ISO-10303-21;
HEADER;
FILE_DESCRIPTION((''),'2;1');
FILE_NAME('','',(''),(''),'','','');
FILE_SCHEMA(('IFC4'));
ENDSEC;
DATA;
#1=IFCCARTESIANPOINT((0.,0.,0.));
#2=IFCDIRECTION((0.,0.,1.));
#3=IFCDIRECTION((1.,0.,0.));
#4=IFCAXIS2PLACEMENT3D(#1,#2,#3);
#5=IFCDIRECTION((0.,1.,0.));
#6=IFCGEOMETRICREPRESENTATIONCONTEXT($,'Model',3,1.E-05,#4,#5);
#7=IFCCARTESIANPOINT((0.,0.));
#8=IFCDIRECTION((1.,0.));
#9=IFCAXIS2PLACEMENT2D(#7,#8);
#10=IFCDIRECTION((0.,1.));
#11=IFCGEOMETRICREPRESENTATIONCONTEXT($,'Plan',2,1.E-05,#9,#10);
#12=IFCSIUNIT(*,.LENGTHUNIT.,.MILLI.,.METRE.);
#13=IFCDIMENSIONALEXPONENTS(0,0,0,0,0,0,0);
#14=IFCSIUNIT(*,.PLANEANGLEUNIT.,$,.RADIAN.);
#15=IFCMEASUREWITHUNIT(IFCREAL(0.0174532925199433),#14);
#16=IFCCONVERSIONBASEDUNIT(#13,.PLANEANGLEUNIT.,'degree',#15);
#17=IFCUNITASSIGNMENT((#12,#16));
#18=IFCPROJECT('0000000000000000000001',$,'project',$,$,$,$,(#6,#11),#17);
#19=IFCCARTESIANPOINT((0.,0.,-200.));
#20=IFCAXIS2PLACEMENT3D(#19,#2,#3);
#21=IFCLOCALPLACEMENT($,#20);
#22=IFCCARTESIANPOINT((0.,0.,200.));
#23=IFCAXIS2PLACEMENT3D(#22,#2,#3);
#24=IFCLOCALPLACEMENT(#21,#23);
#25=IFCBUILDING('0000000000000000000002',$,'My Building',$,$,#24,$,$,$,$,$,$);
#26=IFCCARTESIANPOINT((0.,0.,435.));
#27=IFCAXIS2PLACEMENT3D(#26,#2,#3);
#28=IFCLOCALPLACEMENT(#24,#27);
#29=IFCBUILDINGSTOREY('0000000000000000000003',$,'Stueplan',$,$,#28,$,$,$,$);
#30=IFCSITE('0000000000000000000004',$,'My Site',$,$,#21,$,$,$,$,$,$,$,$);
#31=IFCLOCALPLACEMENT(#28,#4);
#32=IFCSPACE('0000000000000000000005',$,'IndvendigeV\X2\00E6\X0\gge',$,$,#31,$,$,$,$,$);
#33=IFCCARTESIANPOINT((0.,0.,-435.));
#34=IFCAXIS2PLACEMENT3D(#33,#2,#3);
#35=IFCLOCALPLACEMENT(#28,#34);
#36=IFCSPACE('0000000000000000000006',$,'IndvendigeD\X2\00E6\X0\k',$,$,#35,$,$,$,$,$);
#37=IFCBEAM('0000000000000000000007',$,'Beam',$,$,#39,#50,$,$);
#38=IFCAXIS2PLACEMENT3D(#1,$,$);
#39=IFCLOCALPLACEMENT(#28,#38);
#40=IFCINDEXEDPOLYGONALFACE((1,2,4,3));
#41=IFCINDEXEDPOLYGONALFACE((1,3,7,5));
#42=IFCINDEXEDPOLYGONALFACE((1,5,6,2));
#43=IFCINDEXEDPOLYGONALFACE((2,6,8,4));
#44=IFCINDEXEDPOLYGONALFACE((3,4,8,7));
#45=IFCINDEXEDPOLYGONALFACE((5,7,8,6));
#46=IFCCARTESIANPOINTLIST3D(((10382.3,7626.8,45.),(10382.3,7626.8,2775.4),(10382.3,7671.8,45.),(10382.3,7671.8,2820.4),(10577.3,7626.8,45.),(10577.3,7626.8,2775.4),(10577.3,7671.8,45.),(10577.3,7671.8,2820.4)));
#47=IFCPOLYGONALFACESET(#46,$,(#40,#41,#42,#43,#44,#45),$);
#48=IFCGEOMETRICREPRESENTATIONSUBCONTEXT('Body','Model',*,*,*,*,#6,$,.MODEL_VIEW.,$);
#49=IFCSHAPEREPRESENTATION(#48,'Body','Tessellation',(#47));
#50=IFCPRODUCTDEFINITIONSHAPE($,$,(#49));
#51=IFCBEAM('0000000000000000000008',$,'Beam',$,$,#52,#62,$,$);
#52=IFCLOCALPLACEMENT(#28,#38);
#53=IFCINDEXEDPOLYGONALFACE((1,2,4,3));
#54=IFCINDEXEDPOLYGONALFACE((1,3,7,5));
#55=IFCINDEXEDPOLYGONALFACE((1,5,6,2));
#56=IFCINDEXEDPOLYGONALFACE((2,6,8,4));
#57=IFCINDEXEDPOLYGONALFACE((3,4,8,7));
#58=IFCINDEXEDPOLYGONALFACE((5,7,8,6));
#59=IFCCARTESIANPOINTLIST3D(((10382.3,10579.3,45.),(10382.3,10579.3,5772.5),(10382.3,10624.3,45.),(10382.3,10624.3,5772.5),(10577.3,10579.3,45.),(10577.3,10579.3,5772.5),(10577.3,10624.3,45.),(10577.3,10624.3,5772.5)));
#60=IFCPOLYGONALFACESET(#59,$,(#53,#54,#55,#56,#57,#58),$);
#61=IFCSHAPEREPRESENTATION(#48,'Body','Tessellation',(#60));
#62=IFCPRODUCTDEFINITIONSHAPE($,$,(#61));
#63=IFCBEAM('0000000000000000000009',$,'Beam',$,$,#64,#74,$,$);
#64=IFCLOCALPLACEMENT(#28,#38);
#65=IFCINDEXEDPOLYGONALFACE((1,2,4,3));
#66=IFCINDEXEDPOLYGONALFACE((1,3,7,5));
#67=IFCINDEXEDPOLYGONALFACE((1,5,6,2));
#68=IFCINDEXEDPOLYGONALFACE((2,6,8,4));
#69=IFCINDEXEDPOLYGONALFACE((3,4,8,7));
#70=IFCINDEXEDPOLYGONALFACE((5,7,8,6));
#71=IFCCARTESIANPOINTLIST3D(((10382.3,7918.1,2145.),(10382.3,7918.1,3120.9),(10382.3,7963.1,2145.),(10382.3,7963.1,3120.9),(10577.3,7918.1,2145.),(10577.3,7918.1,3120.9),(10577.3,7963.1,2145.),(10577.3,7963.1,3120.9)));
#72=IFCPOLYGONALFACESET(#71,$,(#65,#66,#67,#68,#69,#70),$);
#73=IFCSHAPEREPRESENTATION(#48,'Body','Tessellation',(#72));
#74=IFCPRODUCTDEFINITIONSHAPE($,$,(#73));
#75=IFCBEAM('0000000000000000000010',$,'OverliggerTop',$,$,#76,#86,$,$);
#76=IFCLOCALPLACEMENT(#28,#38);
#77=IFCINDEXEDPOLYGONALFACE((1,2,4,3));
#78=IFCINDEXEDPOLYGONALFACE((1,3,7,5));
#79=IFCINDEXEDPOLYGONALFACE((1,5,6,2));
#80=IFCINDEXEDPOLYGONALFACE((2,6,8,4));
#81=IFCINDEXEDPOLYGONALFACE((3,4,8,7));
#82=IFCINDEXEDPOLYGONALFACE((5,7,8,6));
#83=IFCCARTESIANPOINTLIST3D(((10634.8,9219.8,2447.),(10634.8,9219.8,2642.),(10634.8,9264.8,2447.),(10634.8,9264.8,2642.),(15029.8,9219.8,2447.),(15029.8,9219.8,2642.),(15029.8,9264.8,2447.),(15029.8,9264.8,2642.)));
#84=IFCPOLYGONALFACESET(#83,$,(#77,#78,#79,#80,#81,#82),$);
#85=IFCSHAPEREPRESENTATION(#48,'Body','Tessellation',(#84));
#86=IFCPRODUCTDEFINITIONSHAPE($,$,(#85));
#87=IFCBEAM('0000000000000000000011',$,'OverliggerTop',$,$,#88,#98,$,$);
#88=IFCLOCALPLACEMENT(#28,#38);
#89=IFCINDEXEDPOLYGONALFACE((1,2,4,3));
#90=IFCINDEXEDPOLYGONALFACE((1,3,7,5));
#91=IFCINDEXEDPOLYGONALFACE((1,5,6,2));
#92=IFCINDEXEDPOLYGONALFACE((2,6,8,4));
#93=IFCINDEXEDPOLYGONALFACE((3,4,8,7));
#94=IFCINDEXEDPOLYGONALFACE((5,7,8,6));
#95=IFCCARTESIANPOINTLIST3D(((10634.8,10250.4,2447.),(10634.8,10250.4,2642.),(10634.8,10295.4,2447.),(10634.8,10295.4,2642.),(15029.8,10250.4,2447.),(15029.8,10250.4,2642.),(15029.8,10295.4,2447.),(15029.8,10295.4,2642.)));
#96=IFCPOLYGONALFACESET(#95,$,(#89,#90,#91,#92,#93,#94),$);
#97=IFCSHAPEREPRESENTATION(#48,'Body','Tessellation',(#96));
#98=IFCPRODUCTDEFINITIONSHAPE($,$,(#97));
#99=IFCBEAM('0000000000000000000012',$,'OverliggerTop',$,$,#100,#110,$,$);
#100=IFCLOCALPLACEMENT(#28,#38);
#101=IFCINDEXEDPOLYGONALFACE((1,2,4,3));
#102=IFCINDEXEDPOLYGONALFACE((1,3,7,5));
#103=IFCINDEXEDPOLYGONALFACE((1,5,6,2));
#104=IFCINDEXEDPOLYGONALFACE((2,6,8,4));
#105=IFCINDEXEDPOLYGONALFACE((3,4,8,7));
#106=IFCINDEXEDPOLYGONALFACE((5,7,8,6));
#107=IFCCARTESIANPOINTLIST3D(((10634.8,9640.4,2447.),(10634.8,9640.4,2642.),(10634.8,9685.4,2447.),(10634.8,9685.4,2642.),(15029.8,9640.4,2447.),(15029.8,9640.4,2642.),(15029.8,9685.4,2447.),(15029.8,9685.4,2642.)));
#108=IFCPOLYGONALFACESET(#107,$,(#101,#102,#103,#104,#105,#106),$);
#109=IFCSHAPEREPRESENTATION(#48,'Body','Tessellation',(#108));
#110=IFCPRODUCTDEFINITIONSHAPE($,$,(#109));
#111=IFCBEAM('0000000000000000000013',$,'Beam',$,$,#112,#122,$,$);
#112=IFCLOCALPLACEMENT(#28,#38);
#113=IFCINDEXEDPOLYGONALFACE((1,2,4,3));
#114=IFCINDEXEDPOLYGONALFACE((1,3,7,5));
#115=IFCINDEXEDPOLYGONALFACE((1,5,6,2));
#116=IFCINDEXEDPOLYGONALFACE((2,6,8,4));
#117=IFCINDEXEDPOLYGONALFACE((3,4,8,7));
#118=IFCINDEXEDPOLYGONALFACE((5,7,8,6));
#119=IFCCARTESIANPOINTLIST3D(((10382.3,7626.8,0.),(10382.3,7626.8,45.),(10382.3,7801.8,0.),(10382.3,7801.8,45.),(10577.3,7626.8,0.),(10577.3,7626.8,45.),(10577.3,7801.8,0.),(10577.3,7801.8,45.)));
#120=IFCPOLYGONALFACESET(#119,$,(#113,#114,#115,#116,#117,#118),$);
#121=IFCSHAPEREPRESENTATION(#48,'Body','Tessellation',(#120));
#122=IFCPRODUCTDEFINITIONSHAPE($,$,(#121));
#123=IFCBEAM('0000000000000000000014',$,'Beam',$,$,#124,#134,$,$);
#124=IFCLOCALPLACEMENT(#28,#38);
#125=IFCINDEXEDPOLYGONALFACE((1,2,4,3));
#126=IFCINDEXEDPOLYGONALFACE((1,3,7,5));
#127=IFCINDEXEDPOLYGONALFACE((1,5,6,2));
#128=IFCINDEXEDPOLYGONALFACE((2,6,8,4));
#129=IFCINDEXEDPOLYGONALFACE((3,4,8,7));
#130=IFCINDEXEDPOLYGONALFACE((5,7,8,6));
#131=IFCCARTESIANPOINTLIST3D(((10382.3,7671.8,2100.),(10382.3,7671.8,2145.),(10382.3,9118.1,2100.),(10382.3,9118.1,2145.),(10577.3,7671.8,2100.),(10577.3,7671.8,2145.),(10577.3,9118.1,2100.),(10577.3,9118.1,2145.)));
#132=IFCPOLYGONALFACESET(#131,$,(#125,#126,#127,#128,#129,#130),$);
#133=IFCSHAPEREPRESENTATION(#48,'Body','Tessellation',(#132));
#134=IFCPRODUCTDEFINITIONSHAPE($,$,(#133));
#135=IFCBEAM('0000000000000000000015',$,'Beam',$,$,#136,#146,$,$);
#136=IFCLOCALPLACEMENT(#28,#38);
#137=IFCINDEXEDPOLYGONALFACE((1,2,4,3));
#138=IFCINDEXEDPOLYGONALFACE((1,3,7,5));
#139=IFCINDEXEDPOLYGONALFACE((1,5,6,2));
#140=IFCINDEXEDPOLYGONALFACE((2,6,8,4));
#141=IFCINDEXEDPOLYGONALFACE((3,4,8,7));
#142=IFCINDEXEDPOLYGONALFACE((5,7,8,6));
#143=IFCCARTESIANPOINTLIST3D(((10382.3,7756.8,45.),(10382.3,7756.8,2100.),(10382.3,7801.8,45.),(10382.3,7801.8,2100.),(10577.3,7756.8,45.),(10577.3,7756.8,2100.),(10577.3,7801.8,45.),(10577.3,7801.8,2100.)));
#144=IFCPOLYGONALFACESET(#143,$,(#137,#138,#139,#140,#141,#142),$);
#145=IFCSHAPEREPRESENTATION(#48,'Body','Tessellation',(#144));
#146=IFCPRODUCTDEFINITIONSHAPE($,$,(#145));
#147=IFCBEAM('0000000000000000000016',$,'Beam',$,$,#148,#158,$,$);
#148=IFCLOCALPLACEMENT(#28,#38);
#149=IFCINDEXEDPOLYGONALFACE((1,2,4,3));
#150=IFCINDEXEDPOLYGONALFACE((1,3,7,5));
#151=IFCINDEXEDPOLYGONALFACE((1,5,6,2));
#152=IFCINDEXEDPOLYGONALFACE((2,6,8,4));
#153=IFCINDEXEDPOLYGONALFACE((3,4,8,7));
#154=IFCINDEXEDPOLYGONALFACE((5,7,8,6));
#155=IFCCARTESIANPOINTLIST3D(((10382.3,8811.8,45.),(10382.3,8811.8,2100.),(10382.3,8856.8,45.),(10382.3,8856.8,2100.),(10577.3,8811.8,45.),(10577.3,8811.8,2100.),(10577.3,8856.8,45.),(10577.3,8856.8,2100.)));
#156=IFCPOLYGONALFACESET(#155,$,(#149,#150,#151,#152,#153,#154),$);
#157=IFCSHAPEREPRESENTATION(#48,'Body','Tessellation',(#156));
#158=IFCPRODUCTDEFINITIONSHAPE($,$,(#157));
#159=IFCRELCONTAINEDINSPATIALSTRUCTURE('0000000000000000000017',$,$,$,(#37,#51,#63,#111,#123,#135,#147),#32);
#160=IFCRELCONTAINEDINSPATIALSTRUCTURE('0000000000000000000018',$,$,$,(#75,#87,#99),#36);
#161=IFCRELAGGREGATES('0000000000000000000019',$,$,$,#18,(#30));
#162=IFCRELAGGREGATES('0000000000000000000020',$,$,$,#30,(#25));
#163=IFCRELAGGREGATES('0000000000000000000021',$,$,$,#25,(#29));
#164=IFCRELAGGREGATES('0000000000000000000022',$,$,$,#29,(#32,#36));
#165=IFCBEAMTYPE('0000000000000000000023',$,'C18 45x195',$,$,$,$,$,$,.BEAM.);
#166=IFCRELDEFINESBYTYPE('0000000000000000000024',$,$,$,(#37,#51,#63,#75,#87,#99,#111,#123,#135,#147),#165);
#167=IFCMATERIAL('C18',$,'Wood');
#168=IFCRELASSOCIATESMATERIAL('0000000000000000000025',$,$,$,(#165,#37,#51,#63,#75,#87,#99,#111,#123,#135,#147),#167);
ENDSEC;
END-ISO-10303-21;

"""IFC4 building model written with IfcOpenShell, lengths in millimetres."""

from ifc_helpers import new_model, entity, si_unit, converted_unit, direction, frame, origin_with_axes, origin_2d_with_axis, place, context, subcontext, project, spatial, rectangle, extrude, clip, halfspace, material, material_profile, profile_set, profile_usage, type_object, element, save


model = new_model("IFC4")

# Units and contexts
model_context = context("Model", 3, precision=1e-05, world=origin_with_axes(), true_north=direction((0.0, 1.0, 0.0)))
plan_context = context("Plan", 2, precision=1e-05, world=origin_2d_with_axis(), true_north=direction((0.0, 1.0)))
body_context_1 = subcontext(model_context, "Body", "Model", "MODEL_VIEW")
ifc_project = project(units=[si_unit("LENGTHUNIT", "METRE", prefix="MILLI"), converted_unit("PLANEANGLEUNIT", "degree", entity("IfcReal", 0.0174532925199433), si_unit("PLANEANGLEUNIT", "RADIAN"), dimensions=[0, 0, 0, 0, 0, 0, 0])], contexts=[model_context, plan_context])

# Site, building, storey
site_placement = place(None, frame((0.0, 0.0, -200.0), z_axis=(0.0, 0.0, 1.0), x_axis=(1.0, 0.0, 0.0)))
site = spatial("IfcSite", under=ifc_project, at=site_placement, Name="My Site")
building_placement = place(site_placement, frame((0.0, 0.0, 200.0), z_axis=(0.0, 0.0, 1.0), x_axis=(1.0, 0.0, 0.0)))
building = spatial("IfcBuilding", under=site, at=building_placement, Name="My Building")
storey_placement = place(building_placement, frame((0.0, 0.0, 435.0), z_axis=(0.0, 0.0, 1.0), x_axis=(1.0, 0.0, 0.0)))
storey = spatial("IfcBuildingStorey", under=building, at=storey_placement, Name="Stueplan")

# Shared definitions
ifc_material = material(Name="C18", Category="Wood")

# Shared definitions
space_1_placement = place(storey_placement, frame((0.0, 0.0, 0.0), z_axis=(0.0, 0.0, 1.0), x_axis=(1.0, 0.0, 0.0)))
space_1 = spatial("IfcSpace", under=storey, at=space_1_placement, Name="IndvendigeVægge")

# Beams
ifc_material_profile_1 = material_profile(ifc_material, rectangle(XDim=45.0, YDim=195.0))
ifc_profile_set_1 = profile_set([ifc_material_profile_1], Name="woodStructural")
beam_type_1 = type_object("IfcBeamType", Name="C18 45x195", PredefinedType="BEAM", material=ifc_profile_set_1)
ifc_profile_usage_1 = profile_usage(ifc_profile_set_1)
beam_1_placement = place(space_1_placement, frame((10479.8, 7649.3, 45.0), z_axis=(0.0, 0.0, 1.0), x_axis=(0.0, 1.0, 0.0)))
element("IfcBeam", 1, at=beam_1_placement, inside=space_1, type_object=beam_type_1, material=ifc_profile_usage_1, Name="Beam", context=body_context_1, shape_type="Clipping", body=[
    clip(extrude(rectangle(XDim=45.0, YDim=195.0), origin_with_axes(), (0.0, 0.0, 1.0), 2947.9), halfspace(frame((-144.5, 0.0, 2608.4), z_axis=(-0.707107, 0.0, 0.707107), x_axis=(0.0, 1.0, 0.0)), False)),
])
ifc_profile_usage_2 = profile_usage(ifc_profile_set_1)
beam_2_placement = place(space_1_placement, frame((10479.8, 10601.8, 45.0), z_axis=(0.0, 0.0, 1.0), x_axis=(0.0, 1.0, 0.0)))
element("IfcBeam", 2, at=beam_2_placement, inside=space_1, type_object=beam_type_1, material=ifc_profile_usage_2, Name="Beam", context=body_context_1, shape_type="SweptSolid", body=[
    extrude(rectangle(XDim=45.0, YDim=195.0), origin_with_axes(), (0.0, 0.0, 1.0), 5727.5),
])
ifc_profile_usage_3 = profile_usage(ifc_profile_set_1)
beam_3_placement = place(space_1_placement, frame((10479.8, 7940.6, 2145.0), z_axis=(0.0, 0.0, 1.0), x_axis=(0.0, 1.0, 0.0)))
element("IfcBeam", 3, at=beam_3_placement, inside=space_1, type_object=beam_type_1, material=ifc_profile_usage_3, Name="Beam", context=body_context_1, shape_type="SweptSolid", body=[
    extrude(rectangle(XDim=45.0, YDim=195.0), origin_with_axes(), (0.0, 0.0, 1.0), 975.9),
])

# Shared definitions
space_2_placement = place(storey_placement, frame((0.0, 0.0, -435.0), z_axis=(0.0, 0.0, 1.0), x_axis=(1.0, 0.0, 0.0)))
space_2 = spatial("IfcSpace", under=storey, at=space_2_placement, Name="IndvendigeDæk")

# Beams
ifc_profile_usage_4 = profile_usage(ifc_profile_set_1)
beam_4_placement = place(space_2_placement, frame((10634.8, 9242.3, 2979.5), z_axis=(1.0, 0.000001, 0.0), x_axis=(0.000001, -1.0, 0.0)))
element("IfcBeam", 4, at=beam_4_placement, inside=space_2, type_object=beam_type_1, material=ifc_profile_usage_4, Name="OverliggerTop", context=body_context_1, shape_type="SweptSolid", body=[
    extrude(rectangle(XDim=45.0, YDim=195.0), origin_with_axes(), (0.0, 0.0, 1.0), 4395.0),
])
ifc_profile_usage_5 = profile_usage(ifc_profile_set_1)
beam_5_placement = place(space_2_placement, frame((10634.8, 10272.9, 2979.5), z_axis=(1.0, 0.000001, 0.0), x_axis=(0.000001, -1.0, 0.0)))
element("IfcBeam", 5, at=beam_5_placement, inside=space_2, type_object=beam_type_1, material=ifc_profile_usage_5, Name="OverliggerTop", context=body_context_1, shape_type="SweptSolid", body=[
    extrude(rectangle(XDim=45.0, YDim=195.0), origin_with_axes(), (0.0, 0.0, 1.0), 4395.0),
])
ifc_profile_usage_6 = profile_usage(ifc_profile_set_1)
beam_6_placement = place(space_2_placement, frame((10634.8, 9662.9, 2979.5), z_axis=(1.0, 0.000001, 0.0), x_axis=(0.000001, -1.0, 0.0)))
element("IfcBeam", 6, at=beam_6_placement, inside=space_2, type_object=beam_type_1, material=ifc_profile_usage_6, Name="OverliggerTop", context=body_context_1, shape_type="SweptSolid", body=[
    extrude(rectangle(XDim=45.0, YDim=195.0), origin_with_axes(), (0.0, 0.0, 1.0), 4395.0),
])
ifc_profile_usage_7 = profile_usage(ifc_profile_set_1)
beam_7_placement = place(space_1_placement, frame((10479.8, 7801.8, 22.5), z_axis=(0.0, -1.0, 0.0), x_axis=(0.0, 0.0, 1.0)))
element("IfcBeam", 7, at=beam_7_placement, inside=space_1, type_object=beam_type_1, material=ifc_profile_usage_7, Name="Beam", context=body_context_1, shape_type="SweptSolid", body=[
    extrude(rectangle(XDim=45.0, YDim=195.0), origin_with_axes(), (0.0, 0.0, 1.0), 175.0),
])
ifc_profile_usage_8 = profile_usage(ifc_profile_set_1)
beam_8_placement = place(space_1_placement, frame((10479.8, 9118.1, 2122.5), z_axis=(0.0, -1.0, 0.0), x_axis=(0.0, 0.0, 1.0)))
element("IfcBeam", 8, at=beam_8_placement, inside=space_1, type_object=beam_type_1, material=ifc_profile_usage_8, Name="Beam", context=body_context_1, shape_type="SweptSolid", body=[
    extrude(rectangle(XDim=45.0, YDim=195.0), origin_with_axes(), (0.0, 0.0, 1.0), 1446.3),
])
ifc_profile_usage_9 = profile_usage(ifc_profile_set_1)
beam_9_placement = place(space_1_placement, frame((10479.8, 7779.3, 45.0), z_axis=(0.0, 0.0, 1.0), x_axis=(0.0, -1.0, 0.0)))
element("IfcBeam", 9, at=beam_9_placement, inside=space_1, type_object=beam_type_1, material=ifc_profile_usage_9, Name="Beam", context=body_context_1, shape_type="SweptSolid", body=[
    extrude(rectangle(XDim=45.0, YDim=195.0), origin_with_axes(), (0.0, 0.0, 1.0), 2055.0),
])
ifc_profile_usage_10 = profile_usage(ifc_profile_set_1)
beam_10_placement = place(space_1_placement, frame((10479.8, 8834.3, 45.0), z_axis=(0.0, 0.0, 1.0), x_axis=(0.0, -1.0, 0.0)))
element("IfcBeam", 10, at=beam_10_placement, inside=space_1, type_object=beam_type_1, material=ifc_profile_usage_10, Name="Beam", context=body_context_1, shape_type="SweptSolid", body=[
    extrude(rectangle(XDim=45.0, YDim=195.0), origin_with_axes(), (0.0, 0.0, 1.0), 2055.0),
])

save(model, "model.ifc")
